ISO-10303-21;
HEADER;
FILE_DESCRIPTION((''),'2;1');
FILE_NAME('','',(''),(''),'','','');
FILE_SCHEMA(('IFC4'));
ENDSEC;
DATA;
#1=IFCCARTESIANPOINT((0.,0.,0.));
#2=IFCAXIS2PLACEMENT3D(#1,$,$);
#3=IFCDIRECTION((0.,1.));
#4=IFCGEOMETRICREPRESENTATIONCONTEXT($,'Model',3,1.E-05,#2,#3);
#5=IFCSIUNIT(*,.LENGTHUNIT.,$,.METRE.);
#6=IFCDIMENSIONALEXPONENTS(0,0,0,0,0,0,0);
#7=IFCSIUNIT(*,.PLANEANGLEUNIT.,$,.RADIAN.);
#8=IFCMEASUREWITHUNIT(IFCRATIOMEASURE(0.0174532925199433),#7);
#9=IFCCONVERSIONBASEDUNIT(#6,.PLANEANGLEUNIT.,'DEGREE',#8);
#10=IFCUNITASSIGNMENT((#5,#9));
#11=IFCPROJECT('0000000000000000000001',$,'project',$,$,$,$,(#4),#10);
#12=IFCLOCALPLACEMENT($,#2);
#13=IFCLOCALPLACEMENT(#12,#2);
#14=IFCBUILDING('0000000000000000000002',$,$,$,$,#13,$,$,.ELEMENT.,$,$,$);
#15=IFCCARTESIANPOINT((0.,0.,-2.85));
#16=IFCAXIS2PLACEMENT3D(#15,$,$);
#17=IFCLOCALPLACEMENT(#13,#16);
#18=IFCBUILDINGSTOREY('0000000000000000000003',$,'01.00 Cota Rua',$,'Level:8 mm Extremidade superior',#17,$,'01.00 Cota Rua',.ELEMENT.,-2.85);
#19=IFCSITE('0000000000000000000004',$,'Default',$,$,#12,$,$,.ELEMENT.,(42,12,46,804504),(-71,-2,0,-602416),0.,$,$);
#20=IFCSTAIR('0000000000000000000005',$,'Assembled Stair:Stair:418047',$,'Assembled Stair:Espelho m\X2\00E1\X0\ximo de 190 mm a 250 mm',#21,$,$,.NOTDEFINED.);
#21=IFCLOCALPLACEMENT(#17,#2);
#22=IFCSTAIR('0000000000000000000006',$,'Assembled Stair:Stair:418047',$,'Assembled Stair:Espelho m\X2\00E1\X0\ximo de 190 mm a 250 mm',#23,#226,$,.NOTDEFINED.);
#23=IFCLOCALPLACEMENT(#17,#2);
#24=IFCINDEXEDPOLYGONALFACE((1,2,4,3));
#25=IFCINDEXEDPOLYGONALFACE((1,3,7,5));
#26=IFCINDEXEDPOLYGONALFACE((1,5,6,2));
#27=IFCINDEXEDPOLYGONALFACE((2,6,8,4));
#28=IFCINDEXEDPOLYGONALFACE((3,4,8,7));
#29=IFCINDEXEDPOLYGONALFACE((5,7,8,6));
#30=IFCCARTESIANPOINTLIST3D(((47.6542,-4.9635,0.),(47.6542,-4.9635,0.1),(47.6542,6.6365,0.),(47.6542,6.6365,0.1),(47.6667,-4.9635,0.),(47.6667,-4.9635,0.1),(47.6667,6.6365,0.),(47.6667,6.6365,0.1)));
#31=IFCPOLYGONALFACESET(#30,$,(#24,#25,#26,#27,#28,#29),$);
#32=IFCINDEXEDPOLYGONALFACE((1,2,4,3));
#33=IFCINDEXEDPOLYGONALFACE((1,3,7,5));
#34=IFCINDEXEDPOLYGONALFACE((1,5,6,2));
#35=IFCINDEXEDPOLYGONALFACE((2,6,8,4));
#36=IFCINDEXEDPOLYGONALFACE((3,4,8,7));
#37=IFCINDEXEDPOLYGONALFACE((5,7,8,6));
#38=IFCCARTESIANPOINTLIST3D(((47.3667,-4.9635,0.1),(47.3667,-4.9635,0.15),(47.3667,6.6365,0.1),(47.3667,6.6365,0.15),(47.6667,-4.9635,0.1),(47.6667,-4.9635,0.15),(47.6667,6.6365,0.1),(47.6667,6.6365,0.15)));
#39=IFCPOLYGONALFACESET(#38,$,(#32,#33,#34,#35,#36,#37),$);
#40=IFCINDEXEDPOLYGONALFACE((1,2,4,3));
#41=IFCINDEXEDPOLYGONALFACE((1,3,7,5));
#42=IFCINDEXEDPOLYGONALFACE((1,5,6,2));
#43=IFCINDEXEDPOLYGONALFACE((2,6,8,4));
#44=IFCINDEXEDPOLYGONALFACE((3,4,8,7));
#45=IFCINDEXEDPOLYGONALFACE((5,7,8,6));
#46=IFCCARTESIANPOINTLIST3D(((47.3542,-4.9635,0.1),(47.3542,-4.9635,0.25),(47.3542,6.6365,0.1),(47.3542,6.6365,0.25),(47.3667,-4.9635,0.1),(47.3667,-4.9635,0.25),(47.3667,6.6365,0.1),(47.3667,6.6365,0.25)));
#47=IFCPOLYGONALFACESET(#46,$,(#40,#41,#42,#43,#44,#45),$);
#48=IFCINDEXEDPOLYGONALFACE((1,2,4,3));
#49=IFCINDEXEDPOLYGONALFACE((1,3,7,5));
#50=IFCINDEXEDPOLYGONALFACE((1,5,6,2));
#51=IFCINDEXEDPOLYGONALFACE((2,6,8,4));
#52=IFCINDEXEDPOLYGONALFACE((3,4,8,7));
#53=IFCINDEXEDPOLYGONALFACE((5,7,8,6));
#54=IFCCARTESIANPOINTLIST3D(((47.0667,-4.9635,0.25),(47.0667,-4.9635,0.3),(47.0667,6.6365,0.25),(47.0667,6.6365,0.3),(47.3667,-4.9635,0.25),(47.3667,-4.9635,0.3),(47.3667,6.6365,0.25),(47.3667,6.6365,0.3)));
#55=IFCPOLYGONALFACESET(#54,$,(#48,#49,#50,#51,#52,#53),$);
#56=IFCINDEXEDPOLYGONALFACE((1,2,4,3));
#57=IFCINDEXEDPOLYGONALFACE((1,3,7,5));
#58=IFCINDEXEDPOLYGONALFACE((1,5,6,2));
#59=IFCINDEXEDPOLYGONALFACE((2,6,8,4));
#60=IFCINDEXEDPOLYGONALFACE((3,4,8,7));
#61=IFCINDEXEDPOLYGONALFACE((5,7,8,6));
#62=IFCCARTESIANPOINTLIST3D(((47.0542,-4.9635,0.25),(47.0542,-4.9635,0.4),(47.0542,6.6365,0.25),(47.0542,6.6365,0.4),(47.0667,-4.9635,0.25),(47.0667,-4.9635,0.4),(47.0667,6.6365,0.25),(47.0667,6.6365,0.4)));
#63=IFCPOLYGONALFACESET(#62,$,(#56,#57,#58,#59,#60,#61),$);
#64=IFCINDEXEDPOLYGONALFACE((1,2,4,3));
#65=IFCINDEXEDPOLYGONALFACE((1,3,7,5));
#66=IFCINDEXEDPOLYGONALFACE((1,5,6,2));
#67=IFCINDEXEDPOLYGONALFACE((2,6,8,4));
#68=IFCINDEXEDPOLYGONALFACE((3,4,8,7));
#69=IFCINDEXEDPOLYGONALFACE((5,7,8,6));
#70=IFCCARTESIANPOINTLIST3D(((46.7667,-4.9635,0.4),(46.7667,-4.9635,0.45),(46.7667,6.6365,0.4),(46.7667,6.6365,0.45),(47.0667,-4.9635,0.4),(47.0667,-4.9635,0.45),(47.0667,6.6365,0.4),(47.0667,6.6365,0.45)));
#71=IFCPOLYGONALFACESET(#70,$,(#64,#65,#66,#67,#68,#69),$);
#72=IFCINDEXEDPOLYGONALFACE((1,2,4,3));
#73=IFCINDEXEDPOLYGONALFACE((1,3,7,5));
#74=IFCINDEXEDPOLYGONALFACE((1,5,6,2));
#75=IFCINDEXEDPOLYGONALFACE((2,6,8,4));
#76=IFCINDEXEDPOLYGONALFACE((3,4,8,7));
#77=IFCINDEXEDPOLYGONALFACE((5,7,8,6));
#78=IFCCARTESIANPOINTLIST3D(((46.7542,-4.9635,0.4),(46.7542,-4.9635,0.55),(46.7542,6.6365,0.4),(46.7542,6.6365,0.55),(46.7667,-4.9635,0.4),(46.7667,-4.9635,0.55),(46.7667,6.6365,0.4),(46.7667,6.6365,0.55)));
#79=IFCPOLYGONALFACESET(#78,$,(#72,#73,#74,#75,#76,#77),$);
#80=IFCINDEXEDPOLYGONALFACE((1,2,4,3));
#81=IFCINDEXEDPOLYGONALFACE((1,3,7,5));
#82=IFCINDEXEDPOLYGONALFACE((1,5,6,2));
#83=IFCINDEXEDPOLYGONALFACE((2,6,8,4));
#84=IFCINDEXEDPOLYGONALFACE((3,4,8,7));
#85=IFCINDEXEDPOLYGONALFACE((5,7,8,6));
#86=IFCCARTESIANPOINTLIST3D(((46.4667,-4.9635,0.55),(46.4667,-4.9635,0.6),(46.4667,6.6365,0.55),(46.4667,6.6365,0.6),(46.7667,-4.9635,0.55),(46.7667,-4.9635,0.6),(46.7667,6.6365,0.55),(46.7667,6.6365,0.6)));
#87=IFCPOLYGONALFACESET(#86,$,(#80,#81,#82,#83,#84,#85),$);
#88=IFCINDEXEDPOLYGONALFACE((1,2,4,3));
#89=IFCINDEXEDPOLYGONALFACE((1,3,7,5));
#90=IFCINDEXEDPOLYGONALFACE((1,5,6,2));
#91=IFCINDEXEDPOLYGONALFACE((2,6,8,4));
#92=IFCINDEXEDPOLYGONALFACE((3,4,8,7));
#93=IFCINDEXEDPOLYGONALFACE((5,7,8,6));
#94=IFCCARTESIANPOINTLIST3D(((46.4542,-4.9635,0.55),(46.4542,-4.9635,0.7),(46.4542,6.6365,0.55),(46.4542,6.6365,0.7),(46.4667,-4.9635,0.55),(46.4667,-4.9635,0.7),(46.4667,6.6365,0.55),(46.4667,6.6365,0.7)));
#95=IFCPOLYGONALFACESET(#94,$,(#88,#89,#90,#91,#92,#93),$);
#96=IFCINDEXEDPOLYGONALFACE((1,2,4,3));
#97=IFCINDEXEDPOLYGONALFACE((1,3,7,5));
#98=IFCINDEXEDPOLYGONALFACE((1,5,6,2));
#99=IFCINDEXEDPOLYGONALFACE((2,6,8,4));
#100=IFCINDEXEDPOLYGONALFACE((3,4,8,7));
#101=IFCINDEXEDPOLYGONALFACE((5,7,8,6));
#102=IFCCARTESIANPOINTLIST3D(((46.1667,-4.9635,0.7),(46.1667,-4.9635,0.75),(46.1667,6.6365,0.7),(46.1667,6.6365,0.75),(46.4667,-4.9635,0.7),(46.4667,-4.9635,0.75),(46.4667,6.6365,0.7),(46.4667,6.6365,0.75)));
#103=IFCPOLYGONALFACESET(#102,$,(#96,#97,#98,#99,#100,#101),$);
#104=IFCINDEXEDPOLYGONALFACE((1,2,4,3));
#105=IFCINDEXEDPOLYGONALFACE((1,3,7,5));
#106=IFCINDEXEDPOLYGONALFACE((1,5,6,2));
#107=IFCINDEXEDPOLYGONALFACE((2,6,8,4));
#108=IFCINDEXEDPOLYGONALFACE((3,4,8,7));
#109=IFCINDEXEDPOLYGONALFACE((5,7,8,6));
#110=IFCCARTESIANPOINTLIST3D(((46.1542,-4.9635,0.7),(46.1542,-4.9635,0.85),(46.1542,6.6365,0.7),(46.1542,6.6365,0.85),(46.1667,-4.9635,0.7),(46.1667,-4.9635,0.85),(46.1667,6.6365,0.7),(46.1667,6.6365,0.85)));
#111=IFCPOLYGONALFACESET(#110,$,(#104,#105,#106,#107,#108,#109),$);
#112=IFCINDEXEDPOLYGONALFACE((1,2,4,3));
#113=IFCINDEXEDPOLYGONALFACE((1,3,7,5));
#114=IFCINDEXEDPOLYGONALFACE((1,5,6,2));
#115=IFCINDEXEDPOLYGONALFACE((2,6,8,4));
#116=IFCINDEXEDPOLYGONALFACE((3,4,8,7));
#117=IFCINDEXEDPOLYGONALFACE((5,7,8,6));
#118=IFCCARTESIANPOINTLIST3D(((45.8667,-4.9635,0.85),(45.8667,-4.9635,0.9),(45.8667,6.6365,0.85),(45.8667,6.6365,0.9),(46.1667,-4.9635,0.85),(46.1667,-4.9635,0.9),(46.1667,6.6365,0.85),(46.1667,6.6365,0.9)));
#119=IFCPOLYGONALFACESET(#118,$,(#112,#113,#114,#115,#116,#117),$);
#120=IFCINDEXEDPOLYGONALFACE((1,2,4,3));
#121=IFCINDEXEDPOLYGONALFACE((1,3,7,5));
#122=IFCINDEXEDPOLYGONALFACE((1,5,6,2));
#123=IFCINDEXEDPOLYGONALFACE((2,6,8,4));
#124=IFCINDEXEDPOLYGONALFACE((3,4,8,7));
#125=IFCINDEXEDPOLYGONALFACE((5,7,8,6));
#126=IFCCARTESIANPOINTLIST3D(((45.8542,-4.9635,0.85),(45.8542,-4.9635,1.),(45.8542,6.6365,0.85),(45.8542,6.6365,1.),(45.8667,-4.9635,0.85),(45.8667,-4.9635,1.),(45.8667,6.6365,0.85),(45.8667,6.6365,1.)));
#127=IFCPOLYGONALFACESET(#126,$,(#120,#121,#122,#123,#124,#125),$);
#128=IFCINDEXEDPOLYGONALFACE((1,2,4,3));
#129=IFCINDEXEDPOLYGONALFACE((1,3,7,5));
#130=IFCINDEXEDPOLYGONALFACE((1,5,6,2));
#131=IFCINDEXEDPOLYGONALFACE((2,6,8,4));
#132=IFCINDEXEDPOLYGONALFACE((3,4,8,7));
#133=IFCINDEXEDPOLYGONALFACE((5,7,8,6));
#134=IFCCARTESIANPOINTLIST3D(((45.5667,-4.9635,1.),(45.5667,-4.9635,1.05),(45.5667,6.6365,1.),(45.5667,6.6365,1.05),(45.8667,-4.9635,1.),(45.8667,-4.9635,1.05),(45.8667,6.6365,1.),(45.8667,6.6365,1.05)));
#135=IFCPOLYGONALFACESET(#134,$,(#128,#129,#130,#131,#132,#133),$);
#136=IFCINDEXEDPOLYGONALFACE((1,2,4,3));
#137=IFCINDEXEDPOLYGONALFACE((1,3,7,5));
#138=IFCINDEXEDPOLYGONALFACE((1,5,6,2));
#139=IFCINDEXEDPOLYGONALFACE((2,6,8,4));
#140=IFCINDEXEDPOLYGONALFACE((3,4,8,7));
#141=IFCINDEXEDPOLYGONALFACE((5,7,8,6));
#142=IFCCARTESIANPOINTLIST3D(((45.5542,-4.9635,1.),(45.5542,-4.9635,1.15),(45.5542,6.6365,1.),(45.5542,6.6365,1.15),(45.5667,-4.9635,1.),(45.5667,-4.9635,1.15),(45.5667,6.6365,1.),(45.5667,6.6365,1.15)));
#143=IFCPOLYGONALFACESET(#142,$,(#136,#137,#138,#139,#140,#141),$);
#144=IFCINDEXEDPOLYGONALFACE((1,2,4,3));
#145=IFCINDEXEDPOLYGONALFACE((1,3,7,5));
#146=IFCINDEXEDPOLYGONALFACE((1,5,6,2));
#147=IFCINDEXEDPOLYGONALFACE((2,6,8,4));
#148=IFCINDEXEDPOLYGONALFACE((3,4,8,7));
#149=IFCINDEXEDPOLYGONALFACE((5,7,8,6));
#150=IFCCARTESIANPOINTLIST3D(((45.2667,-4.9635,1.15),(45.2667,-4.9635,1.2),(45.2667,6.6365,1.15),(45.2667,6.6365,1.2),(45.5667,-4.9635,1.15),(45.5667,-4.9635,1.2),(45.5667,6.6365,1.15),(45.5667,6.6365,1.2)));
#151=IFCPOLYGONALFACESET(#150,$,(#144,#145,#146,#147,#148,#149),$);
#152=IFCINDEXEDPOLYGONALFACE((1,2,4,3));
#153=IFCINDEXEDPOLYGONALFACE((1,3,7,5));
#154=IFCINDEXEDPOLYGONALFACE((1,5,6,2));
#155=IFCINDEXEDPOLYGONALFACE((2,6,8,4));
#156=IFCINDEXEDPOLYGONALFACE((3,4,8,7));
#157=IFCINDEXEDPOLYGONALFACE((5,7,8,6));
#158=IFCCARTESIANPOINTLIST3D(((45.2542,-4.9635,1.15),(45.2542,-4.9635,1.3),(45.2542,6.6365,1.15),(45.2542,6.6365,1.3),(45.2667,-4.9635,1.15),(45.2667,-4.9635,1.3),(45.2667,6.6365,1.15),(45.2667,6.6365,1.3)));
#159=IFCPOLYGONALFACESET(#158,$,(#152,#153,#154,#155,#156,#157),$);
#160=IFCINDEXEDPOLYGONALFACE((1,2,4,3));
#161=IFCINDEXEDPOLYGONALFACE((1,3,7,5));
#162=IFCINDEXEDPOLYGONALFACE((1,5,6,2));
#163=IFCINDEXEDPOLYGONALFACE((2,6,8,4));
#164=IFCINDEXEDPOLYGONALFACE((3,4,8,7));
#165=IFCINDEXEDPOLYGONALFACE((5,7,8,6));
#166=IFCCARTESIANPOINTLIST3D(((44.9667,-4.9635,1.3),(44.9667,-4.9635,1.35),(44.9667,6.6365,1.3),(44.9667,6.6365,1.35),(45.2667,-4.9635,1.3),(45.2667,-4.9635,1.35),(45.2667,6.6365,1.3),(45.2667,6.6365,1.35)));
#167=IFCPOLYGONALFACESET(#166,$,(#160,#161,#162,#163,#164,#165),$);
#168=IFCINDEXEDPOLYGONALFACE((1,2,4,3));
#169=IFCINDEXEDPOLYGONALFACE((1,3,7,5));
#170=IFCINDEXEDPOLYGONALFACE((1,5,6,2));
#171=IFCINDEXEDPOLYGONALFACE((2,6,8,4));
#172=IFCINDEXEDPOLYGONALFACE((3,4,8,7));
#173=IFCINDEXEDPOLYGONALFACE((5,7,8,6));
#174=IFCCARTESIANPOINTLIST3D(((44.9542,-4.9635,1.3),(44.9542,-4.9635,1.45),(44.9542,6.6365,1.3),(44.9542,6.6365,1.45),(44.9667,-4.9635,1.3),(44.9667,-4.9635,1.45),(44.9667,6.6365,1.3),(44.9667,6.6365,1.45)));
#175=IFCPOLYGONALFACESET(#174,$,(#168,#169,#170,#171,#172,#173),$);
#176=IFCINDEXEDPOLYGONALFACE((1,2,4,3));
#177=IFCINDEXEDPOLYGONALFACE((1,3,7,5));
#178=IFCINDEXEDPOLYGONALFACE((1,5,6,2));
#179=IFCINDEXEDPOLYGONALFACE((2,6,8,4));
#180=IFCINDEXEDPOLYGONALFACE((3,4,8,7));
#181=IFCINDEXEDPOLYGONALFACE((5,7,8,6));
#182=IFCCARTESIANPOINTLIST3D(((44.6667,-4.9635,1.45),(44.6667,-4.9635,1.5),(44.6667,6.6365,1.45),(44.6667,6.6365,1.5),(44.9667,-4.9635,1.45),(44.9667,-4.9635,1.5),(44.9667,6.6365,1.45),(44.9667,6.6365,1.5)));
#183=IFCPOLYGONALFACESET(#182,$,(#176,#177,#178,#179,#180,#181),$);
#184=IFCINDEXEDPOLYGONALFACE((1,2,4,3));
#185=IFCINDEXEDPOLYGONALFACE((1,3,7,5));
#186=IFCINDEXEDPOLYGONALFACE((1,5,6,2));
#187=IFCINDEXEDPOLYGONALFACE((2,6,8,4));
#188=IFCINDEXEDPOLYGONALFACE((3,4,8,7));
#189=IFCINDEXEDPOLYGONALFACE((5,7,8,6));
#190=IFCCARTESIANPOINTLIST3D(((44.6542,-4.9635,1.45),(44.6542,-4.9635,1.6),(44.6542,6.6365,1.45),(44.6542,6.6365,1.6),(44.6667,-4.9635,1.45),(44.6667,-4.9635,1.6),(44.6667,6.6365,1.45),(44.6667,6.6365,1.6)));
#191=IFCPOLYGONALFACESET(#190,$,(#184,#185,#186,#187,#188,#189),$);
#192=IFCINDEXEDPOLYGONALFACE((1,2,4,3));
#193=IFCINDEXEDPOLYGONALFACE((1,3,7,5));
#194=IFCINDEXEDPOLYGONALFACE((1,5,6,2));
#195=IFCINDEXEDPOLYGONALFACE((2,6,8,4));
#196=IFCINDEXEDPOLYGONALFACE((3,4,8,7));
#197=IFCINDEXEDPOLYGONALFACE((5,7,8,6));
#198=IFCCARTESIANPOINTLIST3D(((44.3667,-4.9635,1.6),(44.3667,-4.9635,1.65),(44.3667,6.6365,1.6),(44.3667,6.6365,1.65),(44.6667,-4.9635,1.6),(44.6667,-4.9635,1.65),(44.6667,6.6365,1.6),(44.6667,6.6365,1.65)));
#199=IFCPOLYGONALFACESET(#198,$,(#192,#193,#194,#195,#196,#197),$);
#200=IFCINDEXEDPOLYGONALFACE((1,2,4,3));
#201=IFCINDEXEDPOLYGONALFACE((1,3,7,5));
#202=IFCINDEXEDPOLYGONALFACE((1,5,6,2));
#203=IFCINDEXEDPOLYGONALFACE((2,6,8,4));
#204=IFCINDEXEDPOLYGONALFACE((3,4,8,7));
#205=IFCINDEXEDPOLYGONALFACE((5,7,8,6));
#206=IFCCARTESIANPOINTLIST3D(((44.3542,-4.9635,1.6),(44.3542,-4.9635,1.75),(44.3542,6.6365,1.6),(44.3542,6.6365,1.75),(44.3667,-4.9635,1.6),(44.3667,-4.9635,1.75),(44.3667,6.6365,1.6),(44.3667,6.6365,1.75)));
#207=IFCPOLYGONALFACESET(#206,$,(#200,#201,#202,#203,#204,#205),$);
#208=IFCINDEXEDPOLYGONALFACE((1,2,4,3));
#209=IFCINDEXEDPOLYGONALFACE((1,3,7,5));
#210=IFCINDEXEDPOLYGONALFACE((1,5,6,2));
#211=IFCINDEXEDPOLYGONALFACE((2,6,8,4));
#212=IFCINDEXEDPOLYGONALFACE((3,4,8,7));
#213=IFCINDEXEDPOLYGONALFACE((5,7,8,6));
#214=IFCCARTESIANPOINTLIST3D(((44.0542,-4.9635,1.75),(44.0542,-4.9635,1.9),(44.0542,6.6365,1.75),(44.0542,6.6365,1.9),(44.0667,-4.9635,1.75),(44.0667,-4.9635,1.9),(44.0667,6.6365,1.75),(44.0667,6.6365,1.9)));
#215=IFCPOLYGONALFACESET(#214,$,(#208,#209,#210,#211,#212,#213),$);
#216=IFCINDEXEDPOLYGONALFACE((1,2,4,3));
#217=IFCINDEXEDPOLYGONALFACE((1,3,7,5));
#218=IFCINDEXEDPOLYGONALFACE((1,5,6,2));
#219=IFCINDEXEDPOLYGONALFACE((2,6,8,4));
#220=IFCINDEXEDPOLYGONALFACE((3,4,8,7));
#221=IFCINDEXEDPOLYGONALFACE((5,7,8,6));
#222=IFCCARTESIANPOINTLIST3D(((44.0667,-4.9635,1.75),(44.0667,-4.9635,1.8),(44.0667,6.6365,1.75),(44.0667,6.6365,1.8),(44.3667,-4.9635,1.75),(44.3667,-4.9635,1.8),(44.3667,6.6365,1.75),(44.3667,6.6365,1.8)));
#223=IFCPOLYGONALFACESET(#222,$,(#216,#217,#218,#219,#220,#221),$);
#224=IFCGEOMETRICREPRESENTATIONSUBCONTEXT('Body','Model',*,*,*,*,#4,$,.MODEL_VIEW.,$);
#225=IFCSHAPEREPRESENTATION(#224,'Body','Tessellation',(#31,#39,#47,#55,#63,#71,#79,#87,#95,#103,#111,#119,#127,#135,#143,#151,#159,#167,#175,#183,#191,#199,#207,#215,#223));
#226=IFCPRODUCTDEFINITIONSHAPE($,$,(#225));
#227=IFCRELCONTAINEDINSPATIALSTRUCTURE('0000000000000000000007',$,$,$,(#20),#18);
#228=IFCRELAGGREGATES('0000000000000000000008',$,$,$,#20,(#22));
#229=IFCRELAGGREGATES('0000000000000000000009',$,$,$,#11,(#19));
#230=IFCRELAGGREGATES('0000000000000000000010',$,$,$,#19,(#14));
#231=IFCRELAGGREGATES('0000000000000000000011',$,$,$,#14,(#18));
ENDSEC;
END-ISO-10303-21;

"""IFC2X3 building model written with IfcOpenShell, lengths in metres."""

from ifc_helpers import new_model, entity, si_unit, converted_unit, direction, frame, frame_2d, origin, origin_2d_with_axis, place, context, subcontext, project, spatial, rectangle, extrude, element, aggregate, save


model = new_model("IFC2X3")

# Units and contexts
model_context = context("Model", 3, precision=1e-05, world=origin(), true_north=direction((0.0, 1.0)))
body_context = subcontext(model_context, "Body", "Model", "MODEL_VIEW")
ifc_project = project(units=[si_unit("LENGTHUNIT", "METRE"), converted_unit("PLANEANGLEUNIT", "DEGREE", entity("IfcRatioMeasure", 0.0174532925199433), si_unit("PLANEANGLEUNIT", "RADIAN"), dimensions=[0, 0, 0, 0, 0, 0, 0])], contexts=[model_context])

# Site, building, storey
site_placement = place(None, origin())
site = spatial("IfcSite", under=ifc_project, at=site_placement, Name="Default", CompositionType="ELEMENT", RefLatitude=(42, 12, 46, 804504), RefLongitude=(-71, -2, 0, -602416), RefElevation=0.0)
building_placement = place(site_placement, origin())
building = spatial("IfcBuilding", under=site, at=building_placement, CompositionType="ELEMENT")
storey_placement = place(building_placement, frame((0.0, 0.0, -2.85)))
storey = spatial("IfcBuildingStorey", under=building, at=storey_placement, Name="01.00 Cota Rua", ObjectType="Level:8 mm Extremidade superior", LongName="01.00 Cota Rua", CompositionType="ELEMENT", Elevation=-2.85)

# Stairs
stair_1_placement = place(storey_placement, frame((44.0542, -4.9635, 0.0)))
stair_1 = element("IfcStair", 1, at=stair_1_placement, inside=storey, Name="Assembled Stair:Stair:418047", ObjectType="Assembled Stair:Espelho máximo de 190 mm a 250 mm", ShapeType="NOTDEFINED")
stair_2_placement = place(stair_1_placement, origin())
stair_2 = element("IfcStair", 2, at=stair_2_placement, Name="Assembled Stair:Stair:418047", ObjectType="Assembled Stair:Espelho máximo de 190 mm a 250 mm", ShapeType="NOTDEFINED", context=body_context, shape_type="SweptSolid", body=[
    extrude(rectangle(XDim=11.6, YDim=0.0125, at=origin_2d_with_axis()), frame((3.6063, 5.8, 0.0), z_axis=(0.0, 0.0, 1.0), x_axis=(0.0, -1.0, 0.0)), (0.0, 0.0, 1.0), 0.1),
    extrude(rectangle(XDim=0.3, YDim=11.6, at=frame_2d((0.0, 0.0), x_axis=(1.0, 0.0))), frame((3.4625, 5.8, 0.1)), (0.0, 0.0, 1.0), 0.05),
    extrude(rectangle(XDim=11.6, YDim=0.0125, at=frame_2d((0.0, 0.0), x_axis=(1.0, 0.0))), frame((3.3063, 5.8, 0.1), z_axis=(0.0, 0.0, 1.0), x_axis=(0.0, -1.0, 0.0)), (0.0, 0.0, 1.0), 0.15),
    extrude(rectangle(XDim=0.3, YDim=11.6, at=origin_2d_with_axis()), frame((3.1625, 5.8, 0.25)), (0.0, 0.0, 1.0), 0.05),
    extrude(rectangle(XDim=11.6, YDim=0.0125, at=frame_2d((0.0, 0.0), x_axis=(1.0, 0.0))), frame((3.0063, 5.8, 0.25), z_axis=(0.0, 0.0, 1.0), x_axis=(0.0, -1.0, 0.0)), (0.0, 0.0, 1.0), 0.15),
    extrude(rectangle(XDim=0.3, YDim=11.6, at=origin_2d_with_axis()), frame((2.8625, 5.8, 0.4)), (0.0, 0.0, 1.0), 0.05),
    extrude(rectangle(XDim=11.6, YDim=0.0125, at=frame_2d((0.0, 0.0), x_axis=(1.0, 0.0))), frame((2.7063, 5.8, 0.4), z_axis=(0.0, 0.0, 1.0), x_axis=(0.0, -1.0, 0.0)), (0.0, 0.0, 1.0), 0.15),
    extrude(rectangle(XDim=0.3, YDim=11.6, at=origin_2d_with_axis()), frame((2.5625, 5.8, 0.55)), (0.0, 0.0, 1.0), 0.05),
    extrude(rectangle(XDim=11.6, YDim=0.0125, at=frame_2d((0.0, 0.0), x_axis=(1.0, 0.0))), frame((2.4063, 5.8, 0.55), z_axis=(0.0, 0.0, 1.0), x_axis=(0.0, -1.0, 0.0)), (0.0, 0.0, 1.0), 0.15),
    extrude(rectangle(XDim=0.3, YDim=11.6, at=origin_2d_with_axis()), frame((2.2625, 5.8, 0.7)), (0.0, 0.0, 1.0), 0.05),
    extrude(rectangle(XDim=11.6, YDim=0.0125, at=frame_2d((0.0, 0.0), x_axis=(1.0, 0.0))), frame((2.1063, 5.8, 0.7), z_axis=(0.0, 0.0, 1.0), x_axis=(0.0, -1.0, 0.0)), (0.0, 0.0, 1.0), 0.15),
    extrude(rectangle(XDim=0.3, YDim=11.6, at=origin_2d_with_axis()), frame((1.9625, 5.8, 0.85)), (0.0, 0.0, 1.0), 0.05),
    extrude(rectangle(XDim=11.6, YDim=0.0125, at=frame_2d((0.0, 0.0), x_axis=(1.0, 0.0))), frame((1.8063, 5.8, 0.85), z_axis=(0.0, 0.0, 1.0), x_axis=(0.0, -1.0, 0.0)), (0.0, 0.0, 1.0), 0.15),
    extrude(rectangle(XDim=0.3, YDim=11.6, at=origin_2d_with_axis()), frame((1.6625, 5.8, 1.0)), (0.0, 0.0, 1.0), 0.05),
    extrude(rectangle(XDim=11.6, YDim=0.0125, at=frame_2d((0.0, 0.0), x_axis=(1.0, 0.0))), frame((1.5063, 5.8, 1.0), z_axis=(0.0, 0.0, 1.0), x_axis=(0.0, -1.0, 0.0)), (0.0, 0.0, 1.0), 0.15),
    extrude(rectangle(XDim=0.3, YDim=11.6, at=origin_2d_with_axis()), frame((1.3625, 5.8, 1.15)), (0.0, 0.0, 1.0), 0.05),
    extrude(rectangle(XDim=11.6, YDim=0.0125, at=frame_2d((0.0, 0.0), x_axis=(1.0, 0.0))), frame((1.2063, 5.8, 1.15), z_axis=(0.0, 0.0, 1.0), x_axis=(0.0, -1.0, 0.0)), (0.0, 0.0, 1.0), 0.15),
    extrude(rectangle(XDim=0.3, YDim=11.6, at=origin_2d_with_axis()), frame((1.0625, 5.8, 1.3)), (0.0, 0.0, 1.0), 0.05),
    extrude(rectangle(XDim=11.6, YDim=0.0125, at=frame_2d((0.0, 0.0), x_axis=(1.0, 0.0))), frame((0.9063, 5.8, 1.3), z_axis=(0.0, 0.0, 1.0), x_axis=(0.0, -1.0, 0.0)), (0.0, 0.0, 1.0), 0.15),
    extrude(rectangle(XDim=0.3, YDim=11.6, at=origin_2d_with_axis()), frame((0.7625, 5.8, 1.45)), (0.0, 0.0, 1.0), 0.05),
    extrude(rectangle(XDim=11.6, YDim=0.0125, at=frame_2d((0.0, 0.0), x_axis=(1.0, 0.0))), frame((0.6063, 5.8, 1.45), z_axis=(0.0, 0.0, 1.0), x_axis=(0.0, -1.0, 0.0)), (0.0, 0.0, 1.0), 0.15),
    extrude(rectangle(XDim=0.3, YDim=11.6, at=origin_2d_with_axis()), frame((0.4625, 5.8, 1.6)), (0.0, 0.0, 1.0), 0.05),
    extrude(rectangle(XDim=11.6, YDim=0.0125, at=frame_2d((0.0, 0.0), x_axis=(1.0, 0.0))), frame((0.3063, 5.8, 1.6), z_axis=(0.0, 0.0, 1.0), x_axis=(0.0, -1.0, 0.0)), (0.0, 0.0, 1.0), 0.15),
    extrude(rectangle(XDim=11.6, YDim=0.0125, at=origin_2d_with_axis()), frame((0.0063, 5.8, 1.75), z_axis=(0.0, 0.0, 1.0), x_axis=(0.0, -1.0, 0.0)), (0.0, 0.0, 1.0), 0.15),
    extrude(rectangle(XDim=0.3, YDim=11.6, at=origin_2d_with_axis()), frame((0.1625, 5.8, 1.75)), (0.0, 0.0, 1.0), 0.05),
])
aggregate(stair_1, [stair_2])

save(model, "model.ifc")
